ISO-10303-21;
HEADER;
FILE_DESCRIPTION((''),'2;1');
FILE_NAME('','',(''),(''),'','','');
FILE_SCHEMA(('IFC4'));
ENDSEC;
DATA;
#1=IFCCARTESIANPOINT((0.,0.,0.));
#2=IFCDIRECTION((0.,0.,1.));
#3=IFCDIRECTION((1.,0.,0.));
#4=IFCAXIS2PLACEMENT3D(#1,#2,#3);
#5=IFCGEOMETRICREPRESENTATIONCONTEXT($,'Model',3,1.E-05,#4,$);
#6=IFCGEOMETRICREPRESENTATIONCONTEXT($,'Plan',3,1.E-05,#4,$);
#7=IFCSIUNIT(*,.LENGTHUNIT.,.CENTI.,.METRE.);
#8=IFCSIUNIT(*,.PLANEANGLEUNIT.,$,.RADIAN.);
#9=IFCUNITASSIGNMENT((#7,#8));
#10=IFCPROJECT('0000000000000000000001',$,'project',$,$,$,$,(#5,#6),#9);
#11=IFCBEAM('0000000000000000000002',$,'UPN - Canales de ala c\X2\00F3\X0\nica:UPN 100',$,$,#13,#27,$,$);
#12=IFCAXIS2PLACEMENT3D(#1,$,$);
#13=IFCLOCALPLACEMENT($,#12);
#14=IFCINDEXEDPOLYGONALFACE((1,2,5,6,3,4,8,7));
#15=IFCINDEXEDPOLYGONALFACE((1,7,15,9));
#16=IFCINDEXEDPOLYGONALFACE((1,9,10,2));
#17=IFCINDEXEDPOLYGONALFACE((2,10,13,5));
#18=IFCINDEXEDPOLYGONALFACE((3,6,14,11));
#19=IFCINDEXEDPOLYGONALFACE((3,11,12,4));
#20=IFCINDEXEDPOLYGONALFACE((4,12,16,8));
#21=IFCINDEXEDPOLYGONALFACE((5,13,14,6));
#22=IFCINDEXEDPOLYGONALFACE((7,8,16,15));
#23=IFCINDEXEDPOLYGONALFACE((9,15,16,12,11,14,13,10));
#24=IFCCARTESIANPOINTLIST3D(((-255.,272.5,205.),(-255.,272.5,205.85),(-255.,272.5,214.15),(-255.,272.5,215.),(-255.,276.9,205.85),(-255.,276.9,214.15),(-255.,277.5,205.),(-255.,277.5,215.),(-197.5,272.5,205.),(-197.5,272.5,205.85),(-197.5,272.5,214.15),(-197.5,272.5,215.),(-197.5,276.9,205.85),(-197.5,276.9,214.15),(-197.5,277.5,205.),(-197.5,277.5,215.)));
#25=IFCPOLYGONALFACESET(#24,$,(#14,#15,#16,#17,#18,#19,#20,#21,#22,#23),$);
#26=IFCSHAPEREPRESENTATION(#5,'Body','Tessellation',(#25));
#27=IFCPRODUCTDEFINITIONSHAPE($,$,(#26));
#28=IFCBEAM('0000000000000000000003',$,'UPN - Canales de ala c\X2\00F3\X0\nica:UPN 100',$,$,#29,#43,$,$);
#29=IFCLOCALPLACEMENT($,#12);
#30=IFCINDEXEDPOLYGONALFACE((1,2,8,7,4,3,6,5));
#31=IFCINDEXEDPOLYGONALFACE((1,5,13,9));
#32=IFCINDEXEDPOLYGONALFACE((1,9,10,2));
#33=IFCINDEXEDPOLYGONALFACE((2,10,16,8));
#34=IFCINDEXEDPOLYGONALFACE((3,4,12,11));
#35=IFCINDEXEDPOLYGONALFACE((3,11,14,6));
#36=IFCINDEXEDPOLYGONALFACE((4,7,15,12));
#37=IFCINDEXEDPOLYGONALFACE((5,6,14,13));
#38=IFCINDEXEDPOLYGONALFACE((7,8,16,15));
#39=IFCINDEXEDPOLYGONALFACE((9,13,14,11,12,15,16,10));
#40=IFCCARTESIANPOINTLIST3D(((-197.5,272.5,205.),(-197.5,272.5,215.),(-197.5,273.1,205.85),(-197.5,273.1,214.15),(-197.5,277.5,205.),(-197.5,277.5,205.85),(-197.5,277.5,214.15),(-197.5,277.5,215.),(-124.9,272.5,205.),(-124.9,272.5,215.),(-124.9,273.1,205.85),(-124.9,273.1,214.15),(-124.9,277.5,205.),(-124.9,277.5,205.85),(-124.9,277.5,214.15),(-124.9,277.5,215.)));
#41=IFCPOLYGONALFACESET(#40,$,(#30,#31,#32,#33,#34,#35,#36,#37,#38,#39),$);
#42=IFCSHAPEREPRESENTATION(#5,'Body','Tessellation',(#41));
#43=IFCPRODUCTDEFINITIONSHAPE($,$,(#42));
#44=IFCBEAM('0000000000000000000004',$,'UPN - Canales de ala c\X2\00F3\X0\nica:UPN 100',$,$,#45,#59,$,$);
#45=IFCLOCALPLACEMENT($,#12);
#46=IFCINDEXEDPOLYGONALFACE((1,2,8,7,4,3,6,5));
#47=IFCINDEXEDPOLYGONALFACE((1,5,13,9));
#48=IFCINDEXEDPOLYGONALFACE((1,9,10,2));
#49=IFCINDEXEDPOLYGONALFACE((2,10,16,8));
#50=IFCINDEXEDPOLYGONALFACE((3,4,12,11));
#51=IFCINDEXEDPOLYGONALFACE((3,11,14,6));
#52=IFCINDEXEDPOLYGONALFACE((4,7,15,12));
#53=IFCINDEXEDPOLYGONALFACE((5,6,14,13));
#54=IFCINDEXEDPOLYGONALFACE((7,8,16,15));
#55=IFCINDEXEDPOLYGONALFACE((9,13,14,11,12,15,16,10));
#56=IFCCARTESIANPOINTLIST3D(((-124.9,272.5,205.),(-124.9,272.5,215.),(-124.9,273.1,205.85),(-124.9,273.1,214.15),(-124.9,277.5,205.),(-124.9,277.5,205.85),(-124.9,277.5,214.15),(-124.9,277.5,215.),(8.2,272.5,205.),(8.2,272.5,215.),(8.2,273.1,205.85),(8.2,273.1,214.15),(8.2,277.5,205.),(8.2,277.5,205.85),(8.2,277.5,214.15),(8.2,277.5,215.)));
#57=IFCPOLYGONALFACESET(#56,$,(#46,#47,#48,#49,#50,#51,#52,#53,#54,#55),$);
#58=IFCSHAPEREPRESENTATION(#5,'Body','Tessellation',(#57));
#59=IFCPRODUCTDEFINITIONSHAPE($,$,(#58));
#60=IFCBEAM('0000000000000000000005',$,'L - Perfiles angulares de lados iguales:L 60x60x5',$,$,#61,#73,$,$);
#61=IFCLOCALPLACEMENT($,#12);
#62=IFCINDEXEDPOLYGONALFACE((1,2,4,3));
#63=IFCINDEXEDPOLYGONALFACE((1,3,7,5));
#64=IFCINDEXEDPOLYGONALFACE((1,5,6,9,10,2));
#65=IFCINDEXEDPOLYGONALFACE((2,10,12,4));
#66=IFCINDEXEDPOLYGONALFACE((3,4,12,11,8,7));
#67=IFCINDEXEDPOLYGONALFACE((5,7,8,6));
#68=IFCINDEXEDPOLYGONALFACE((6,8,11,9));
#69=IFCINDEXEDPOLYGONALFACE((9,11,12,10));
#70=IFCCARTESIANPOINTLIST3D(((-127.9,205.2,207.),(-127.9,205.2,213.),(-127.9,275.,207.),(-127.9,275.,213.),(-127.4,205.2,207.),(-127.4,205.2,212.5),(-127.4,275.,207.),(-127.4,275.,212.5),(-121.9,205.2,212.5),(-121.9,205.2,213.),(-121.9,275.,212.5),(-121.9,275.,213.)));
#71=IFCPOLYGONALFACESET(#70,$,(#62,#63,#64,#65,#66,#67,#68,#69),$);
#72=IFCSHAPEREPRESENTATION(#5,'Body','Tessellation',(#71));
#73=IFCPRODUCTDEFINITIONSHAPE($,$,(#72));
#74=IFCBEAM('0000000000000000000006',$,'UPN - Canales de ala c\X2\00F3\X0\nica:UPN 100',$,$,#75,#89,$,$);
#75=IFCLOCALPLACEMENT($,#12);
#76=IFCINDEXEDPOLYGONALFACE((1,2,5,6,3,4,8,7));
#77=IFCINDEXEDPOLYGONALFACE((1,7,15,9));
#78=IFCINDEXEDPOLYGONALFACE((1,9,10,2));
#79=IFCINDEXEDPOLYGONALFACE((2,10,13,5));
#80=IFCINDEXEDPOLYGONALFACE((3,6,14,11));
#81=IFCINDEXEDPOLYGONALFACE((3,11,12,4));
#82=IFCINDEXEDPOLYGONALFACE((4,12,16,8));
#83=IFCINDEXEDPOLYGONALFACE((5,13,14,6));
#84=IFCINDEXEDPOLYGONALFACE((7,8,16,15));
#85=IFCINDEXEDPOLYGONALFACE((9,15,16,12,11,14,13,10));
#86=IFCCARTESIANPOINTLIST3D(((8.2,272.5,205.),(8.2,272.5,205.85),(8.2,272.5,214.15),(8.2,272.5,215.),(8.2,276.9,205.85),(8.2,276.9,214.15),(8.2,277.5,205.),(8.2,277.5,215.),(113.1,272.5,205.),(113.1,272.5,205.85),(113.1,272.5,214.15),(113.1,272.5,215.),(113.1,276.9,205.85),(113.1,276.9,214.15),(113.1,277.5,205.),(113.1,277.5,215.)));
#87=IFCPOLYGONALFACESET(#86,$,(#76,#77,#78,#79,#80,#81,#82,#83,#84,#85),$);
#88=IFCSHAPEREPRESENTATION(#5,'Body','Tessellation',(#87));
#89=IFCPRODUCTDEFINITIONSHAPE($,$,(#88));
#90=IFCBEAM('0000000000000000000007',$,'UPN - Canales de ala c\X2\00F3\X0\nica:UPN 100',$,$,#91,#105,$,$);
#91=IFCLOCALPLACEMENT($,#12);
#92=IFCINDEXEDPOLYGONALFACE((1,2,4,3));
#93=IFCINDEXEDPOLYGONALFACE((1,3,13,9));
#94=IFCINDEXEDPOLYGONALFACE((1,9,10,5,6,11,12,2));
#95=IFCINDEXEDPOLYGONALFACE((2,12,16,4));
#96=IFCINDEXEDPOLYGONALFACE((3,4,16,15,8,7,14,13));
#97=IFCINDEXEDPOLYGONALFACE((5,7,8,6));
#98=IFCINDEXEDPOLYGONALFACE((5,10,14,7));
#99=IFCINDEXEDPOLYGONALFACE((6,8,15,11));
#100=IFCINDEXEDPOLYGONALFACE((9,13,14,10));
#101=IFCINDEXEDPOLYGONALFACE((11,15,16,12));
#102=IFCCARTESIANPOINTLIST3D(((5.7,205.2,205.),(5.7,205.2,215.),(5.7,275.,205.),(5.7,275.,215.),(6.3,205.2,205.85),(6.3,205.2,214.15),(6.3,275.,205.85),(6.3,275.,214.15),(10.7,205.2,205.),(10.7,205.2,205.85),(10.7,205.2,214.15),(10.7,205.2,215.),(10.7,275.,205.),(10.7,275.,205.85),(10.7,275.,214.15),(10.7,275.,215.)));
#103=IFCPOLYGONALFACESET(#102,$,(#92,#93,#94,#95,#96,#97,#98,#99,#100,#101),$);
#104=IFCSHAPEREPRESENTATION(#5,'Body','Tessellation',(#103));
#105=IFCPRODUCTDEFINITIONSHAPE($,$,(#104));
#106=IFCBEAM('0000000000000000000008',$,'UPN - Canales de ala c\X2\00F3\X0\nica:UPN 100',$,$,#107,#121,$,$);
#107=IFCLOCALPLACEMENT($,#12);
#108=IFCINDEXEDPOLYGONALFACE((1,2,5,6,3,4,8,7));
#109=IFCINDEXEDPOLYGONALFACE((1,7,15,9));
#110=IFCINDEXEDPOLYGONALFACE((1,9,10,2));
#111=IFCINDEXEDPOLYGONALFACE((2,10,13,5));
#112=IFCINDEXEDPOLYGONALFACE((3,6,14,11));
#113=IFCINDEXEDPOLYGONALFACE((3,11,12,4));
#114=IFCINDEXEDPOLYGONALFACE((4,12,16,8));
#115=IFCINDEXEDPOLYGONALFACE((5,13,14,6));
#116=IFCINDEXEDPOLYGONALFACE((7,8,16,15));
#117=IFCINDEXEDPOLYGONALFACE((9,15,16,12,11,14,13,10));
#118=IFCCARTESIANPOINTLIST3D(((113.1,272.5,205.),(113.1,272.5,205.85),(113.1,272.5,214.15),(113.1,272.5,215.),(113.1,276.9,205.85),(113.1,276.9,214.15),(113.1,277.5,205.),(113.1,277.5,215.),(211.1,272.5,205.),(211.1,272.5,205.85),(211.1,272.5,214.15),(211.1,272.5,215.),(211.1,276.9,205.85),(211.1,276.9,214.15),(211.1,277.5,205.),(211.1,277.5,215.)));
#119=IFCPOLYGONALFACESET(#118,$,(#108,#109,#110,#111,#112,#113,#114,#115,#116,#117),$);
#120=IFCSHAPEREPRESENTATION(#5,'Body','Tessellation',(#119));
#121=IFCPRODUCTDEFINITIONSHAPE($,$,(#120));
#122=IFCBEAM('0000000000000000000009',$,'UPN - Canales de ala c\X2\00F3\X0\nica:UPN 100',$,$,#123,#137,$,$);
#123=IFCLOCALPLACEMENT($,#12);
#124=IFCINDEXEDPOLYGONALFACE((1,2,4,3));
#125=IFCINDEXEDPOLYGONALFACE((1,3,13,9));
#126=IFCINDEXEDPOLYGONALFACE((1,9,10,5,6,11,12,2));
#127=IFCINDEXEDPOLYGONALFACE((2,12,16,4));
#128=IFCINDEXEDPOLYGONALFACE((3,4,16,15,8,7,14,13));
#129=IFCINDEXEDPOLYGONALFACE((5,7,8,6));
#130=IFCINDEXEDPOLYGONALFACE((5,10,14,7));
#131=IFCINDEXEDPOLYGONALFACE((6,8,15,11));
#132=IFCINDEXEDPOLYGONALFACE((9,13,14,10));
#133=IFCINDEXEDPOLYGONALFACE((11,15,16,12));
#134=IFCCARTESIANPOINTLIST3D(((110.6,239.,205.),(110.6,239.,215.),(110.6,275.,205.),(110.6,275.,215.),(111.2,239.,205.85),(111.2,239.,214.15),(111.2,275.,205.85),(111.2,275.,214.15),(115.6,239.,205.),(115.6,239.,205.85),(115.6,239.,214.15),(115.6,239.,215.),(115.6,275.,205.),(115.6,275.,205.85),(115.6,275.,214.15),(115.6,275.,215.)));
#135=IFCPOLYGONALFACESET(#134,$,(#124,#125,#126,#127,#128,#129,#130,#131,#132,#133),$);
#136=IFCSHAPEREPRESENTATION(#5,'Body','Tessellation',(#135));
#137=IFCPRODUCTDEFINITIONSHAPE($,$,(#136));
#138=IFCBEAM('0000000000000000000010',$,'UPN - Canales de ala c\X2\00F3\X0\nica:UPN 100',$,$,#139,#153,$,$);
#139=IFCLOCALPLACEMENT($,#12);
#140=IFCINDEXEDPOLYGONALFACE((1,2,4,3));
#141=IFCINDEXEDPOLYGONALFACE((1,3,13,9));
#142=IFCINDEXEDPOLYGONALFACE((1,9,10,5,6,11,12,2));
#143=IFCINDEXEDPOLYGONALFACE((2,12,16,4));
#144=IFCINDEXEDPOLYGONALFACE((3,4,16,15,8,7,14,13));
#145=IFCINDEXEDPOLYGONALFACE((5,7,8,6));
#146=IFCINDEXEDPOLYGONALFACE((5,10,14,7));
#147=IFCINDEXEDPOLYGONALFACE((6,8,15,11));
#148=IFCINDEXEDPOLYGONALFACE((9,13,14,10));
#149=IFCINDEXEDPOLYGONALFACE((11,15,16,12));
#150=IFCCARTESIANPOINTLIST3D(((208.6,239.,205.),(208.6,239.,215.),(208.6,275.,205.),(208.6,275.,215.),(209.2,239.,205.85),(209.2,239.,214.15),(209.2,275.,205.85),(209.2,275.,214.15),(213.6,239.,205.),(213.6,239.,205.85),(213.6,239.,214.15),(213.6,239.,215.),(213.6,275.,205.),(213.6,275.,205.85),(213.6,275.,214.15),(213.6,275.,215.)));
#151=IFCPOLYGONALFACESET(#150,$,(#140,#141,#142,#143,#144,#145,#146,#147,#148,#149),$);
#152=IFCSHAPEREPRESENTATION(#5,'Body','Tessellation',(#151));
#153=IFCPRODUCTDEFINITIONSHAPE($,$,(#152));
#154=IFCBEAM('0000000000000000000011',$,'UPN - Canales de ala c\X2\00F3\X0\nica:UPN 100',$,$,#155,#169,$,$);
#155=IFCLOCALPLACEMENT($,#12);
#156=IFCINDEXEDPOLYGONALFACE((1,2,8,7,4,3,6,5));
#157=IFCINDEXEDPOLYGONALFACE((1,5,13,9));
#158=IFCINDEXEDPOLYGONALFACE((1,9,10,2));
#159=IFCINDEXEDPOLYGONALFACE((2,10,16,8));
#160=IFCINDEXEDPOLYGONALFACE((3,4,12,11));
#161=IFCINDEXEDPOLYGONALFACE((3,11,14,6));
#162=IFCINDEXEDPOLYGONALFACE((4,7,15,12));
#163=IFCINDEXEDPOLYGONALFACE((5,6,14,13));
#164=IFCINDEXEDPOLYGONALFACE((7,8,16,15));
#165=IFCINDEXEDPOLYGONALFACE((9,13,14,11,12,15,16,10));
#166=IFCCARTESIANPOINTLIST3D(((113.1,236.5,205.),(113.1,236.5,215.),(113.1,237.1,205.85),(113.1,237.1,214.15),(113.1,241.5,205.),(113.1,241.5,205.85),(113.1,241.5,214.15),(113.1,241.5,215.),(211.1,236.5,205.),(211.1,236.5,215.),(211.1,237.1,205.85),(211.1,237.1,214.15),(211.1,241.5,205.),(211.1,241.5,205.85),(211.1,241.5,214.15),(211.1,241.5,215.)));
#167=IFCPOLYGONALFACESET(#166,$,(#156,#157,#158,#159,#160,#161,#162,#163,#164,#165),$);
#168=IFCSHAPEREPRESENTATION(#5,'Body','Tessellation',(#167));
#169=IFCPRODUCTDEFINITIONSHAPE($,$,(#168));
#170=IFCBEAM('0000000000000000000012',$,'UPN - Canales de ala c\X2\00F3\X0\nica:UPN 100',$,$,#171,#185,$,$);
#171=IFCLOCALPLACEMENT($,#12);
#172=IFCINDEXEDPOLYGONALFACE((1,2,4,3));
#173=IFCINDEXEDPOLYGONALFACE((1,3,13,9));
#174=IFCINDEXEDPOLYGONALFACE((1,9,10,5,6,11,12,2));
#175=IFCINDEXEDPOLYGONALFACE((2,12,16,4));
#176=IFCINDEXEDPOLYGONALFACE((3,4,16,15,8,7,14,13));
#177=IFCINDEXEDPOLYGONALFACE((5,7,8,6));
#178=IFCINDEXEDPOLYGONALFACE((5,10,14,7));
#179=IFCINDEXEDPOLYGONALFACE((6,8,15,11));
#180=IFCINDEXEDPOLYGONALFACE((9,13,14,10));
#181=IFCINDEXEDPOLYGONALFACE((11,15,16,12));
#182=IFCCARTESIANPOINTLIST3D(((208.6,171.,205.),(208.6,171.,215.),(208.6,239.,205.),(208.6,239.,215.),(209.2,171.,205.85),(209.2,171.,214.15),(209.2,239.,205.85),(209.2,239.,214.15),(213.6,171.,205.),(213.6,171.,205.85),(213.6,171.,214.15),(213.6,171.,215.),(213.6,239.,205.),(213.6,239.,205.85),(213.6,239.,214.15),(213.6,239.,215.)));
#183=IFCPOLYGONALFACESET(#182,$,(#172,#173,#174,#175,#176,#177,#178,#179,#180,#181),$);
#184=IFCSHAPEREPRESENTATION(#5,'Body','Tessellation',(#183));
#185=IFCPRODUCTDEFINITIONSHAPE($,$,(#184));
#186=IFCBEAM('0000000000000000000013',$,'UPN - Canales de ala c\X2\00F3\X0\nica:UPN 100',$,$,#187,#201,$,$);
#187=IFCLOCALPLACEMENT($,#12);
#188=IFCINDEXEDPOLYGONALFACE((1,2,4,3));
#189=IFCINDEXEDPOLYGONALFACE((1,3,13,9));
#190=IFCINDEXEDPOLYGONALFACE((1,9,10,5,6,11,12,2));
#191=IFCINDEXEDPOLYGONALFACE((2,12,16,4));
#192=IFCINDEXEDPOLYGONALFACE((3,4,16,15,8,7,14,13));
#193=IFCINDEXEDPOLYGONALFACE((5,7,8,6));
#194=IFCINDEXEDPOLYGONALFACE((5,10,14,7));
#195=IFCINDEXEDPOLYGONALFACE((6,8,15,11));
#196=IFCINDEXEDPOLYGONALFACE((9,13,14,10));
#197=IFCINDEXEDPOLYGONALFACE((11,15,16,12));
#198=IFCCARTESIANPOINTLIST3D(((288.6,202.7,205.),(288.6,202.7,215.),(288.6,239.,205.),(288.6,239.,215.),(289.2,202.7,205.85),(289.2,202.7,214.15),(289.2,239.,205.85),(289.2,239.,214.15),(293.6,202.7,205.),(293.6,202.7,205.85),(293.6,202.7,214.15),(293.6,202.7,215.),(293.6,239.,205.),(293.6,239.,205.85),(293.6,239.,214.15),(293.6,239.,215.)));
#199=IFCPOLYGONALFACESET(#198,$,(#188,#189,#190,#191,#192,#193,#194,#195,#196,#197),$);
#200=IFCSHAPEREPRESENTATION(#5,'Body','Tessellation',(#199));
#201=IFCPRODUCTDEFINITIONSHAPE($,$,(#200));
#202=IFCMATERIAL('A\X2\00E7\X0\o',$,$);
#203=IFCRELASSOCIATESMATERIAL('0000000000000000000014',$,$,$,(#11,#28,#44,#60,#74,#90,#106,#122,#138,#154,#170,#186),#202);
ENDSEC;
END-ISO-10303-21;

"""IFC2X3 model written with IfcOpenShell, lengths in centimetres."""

from ifc_helpers import new_model, si_unit, frame, frame_2d, origin_with_axes, origin_2d_with_axis, place, context, project, polyline, u_section, outline, extrude, material, element, save


model = new_model("IFC2X3")

# Units and contexts
model_context = context("Model", 3, precision=1e-05, world=origin_with_axes())
plan_context = context("Plan", 3, precision=1e-05, world=origin_with_axes())
ifc_project = project(units=[si_unit("LENGTHUNIT", "METRE", prefix="CENTI"), si_unit("PLANEANGLEUNIT", "RADIAN")], contexts=[model_context, plan_context])

# Shared definitions
ifc_material = material(Name="Aço")

# Beams
beam_1_placement = place(None, frame((-197.5, 275.0, 210.0), z_axis=(-1.0, 0.0, 0.0), x_axis=(0.0, -1.0, 0.0)))
element("IfcBeam", 1, at=beam_1_placement, material=ifc_material, Name="UPN - Canales de ala cónica:UPN 100", context=model_context, shape_type="SweptSolid", body=[
    extrude(u_section(Depth=10.0, FlangeWidth=5.0, WebThickness=0.6, FlangeThickness=0.85, FilletRadius=0.0, EdgeRadius=0.0, FlangeSlope=0.0, CentreOfGravityInX=0.0, at=origin_2d_with_axis()), origin_with_axes(), (0.0, 0.0, 1.0), 57.5),
])
beam_2_placement = place(None, frame((-124.9, 275.0, 210.0), z_axis=(-1.0, 0.0, 0.0), x_axis=(0.0, 1.0, 0.0)))
element("IfcBeam", 2, at=beam_2_placement, material=ifc_material, Name="UPN - Canales de ala cónica:UPN 100", context=model_context, shape_type="SweptSolid", body=[
    extrude(u_section(Depth=10.0, FlangeWidth=5.0, WebThickness=0.6, FlangeThickness=0.85, FilletRadius=0.0, EdgeRadius=0.0, FlangeSlope=0.0, CentreOfGravityInX=0.0, at=origin_2d_with_axis()), origin_with_axes(), (0.0, 0.0, 1.0), 72.6),
])
beam_3_placement = place(None, frame((8.2, 275.0, 210.0), z_axis=(-1.0, 0.0, 0.0), x_axis=(0.0, 1.0, 0.0)))
element("IfcBeam", 3, at=beam_3_placement, material=ifc_material, Name="UPN - Canales de ala cónica:UPN 100", context=model_context, shape_type="SweptSolid", body=[
    extrude(u_section(Depth=10.0, FlangeWidth=5.0, WebThickness=0.6, FlangeThickness=0.85, FilletRadius=0.0, EdgeRadius=0.0, FlangeSlope=0.0, CentreOfGravityInX=0.0, at=origin_2d_with_axis()), origin_with_axes(), (0.0, 0.0, 1.0), 133.1),
])
beam_4_placement = place(None, frame((-124.9, 205.2, 210.0), z_axis=(0.0, 1.0, 0.0), x_axis=(-1.0, 0.0, 0.0)))
element("IfcBeam", 4, at=beam_4_placement, material=ifc_material, Name="L - Perfiles angulares de lados iguales:L 60x60x5", context=model_context, shape_type="SweptSolid", body=[
    extrude(outline(polyline([(3.0, -3.0), (3.0, 3.0), (-3.0, 3.0), (-3.0, 2.5), (2.5, 2.5), (2.5, -3.0), (3.0, -3.0)])), origin_with_axes(), (0.0, 0.0, 1.0), 69.8),
])
beam_5_placement = place(None, frame((113.1, 275.0, 210.0), z_axis=(-1.0, 0.0, 0.0), x_axis=(0.0, -1.0, 0.0)))
element("IfcBeam", 5, at=beam_5_placement, material=ifc_material, Name="UPN - Canales de ala cónica:UPN 100", context=model_context, shape_type="SweptSolid", body=[
    extrude(u_section(Depth=10.0, FlangeWidth=5.0, WebThickness=0.6, FlangeThickness=0.85, FilletRadius=0.0, EdgeRadius=0.0, FlangeSlope=0.0, CentreOfGravityInX=0.0, at=origin_2d_with_axis()), origin_with_axes(), (0.0, 0.0, 1.0), 104.9),
])
beam_6_placement = place(None, frame((8.2, 205.2, 210.0), z_axis=(0.0, 1.0, 0.0), x_axis=(1.0, 0.0, 0.0)))
element("IfcBeam", 6, at=beam_6_placement, material=ifc_material, Name="UPN - Canales de ala cónica:UPN 100", context=model_context, shape_type="SweptSolid", body=[
    extrude(u_section(Depth=10.0, FlangeWidth=5.0, WebThickness=0.6, FlangeThickness=0.85, FilletRadius=0.0, EdgeRadius=0.0, FlangeSlope=0.0, CentreOfGravityInX=0.0, at=frame_2d((0.0, 0.0), x_axis=(1.0, 0.0))), origin_with_axes(), (0.0, 0.0, 1.0), 69.8),
])
beam_7_placement = place(None, frame((211.1, 275.0, 210.0), z_axis=(-1.0, 0.0, 0.0), x_axis=(0.0, -1.0, 0.0)))
element("IfcBeam", 7, at=beam_7_placement, material=ifc_material, Name="UPN - Canales de ala cónica:UPN 100", context=model_context, shape_type="SweptSolid", body=[
    extrude(u_section(Depth=10.0, FlangeWidth=5.0, WebThickness=0.6, FlangeThickness=0.85, FilletRadius=0.0, EdgeRadius=0.0, FlangeSlope=0.0, CentreOfGravityInX=0.0, at=origin_2d_with_axis()), origin_with_axes(), (0.0, 0.0, 1.0), 98.0),
])
for number, where, z_axis, x_axis, name in (
    (8, (113.1, 239.0, 210.0), (0.0, 1.0, 0.0), (1.0, 0.0, 0.0), "UPN - Canales de ala cónica:UPN 100"),
    (9, (211.1, 239.0, 210.0), (0.0, 1.0, 0.0), (1.0, 0.0, 0.0), "UPN - Canales de ala cónica:UPN 100"),
):
    element("IfcBeam", number, at=place(None, frame(where, z_axis=z_axis, x_axis=x_axis)), material=ifc_material, Name=name, context=model_context, shape_type="SweptSolid", body=[
        extrude(u_section(Depth=10.0, FlangeWidth=5.0, WebThickness=0.6, FlangeThickness=0.85, FilletRadius=0.0, EdgeRadius=0.0, FlangeSlope=0.0, CentreOfGravityInX=0.0, at=origin_2d_with_axis()), origin_with_axes(), (0.0, 0.0, 1.0), 36.0),
    ])
beam_8_placement = place(None, frame((211.1, 239.0, 210.0), z_axis=(-1.0, 0.0, 0.0), x_axis=(0.0, 1.0, 0.0)))
element("IfcBeam", 10, at=beam_8_placement, material=ifc_material, Name="UPN - Canales de ala cónica:UPN 100", context=model_context, shape_type="SweptSolid", body=[
    extrude(u_section(Depth=10.0, FlangeWidth=5.0, WebThickness=0.6, FlangeThickness=0.85, FilletRadius=0.0, EdgeRadius=0.0, FlangeSlope=0.0, CentreOfGravityInX=0.0, at=origin_2d_with_axis()), origin_with_axes(), (0.0, 0.0, 1.0), 98.0),
])
beam_9_placement = place(None, frame((211.1, 171.0, 210.0), z_axis=(0.0, 1.0, 0.0), x_axis=(1.0, 0.0, 0.0)))
element("IfcBeam", 11, at=beam_9_placement, material=ifc_material, Name="UPN - Canales de ala cónica:UPN 100", context=model_context, shape_type="SweptSolid", body=[
    extrude(u_section(Depth=10.0, FlangeWidth=5.0, WebThickness=0.6, FlangeThickness=0.85, FilletRadius=0.0, EdgeRadius=0.0, FlangeSlope=0.0, CentreOfGravityInX=0.0, at=origin_2d_with_axis()), origin_with_axes(), (0.0, 0.0, 1.0), 68.0),
])
beam_10_placement = place(None, frame((291.1, 202.7, 210.0), z_axis=(0.0, 1.0, 0.0), x_axis=(1.0, 0.0, 0.0)))
element("IfcBeam", 12, at=beam_10_placement, material=ifc_material, Name="UPN - Canales de ala cónica:UPN 100", context=model_context, shape_type="SweptSolid", body=[
    extrude(u_section(Depth=10.0, FlangeWidth=5.0, WebThickness=0.6, FlangeThickness=0.85, FilletRadius=0.0, EdgeRadius=0.0, FlangeSlope=0.0, CentreOfGravityInX=0.0, at=origin_2d_with_axis()), origin_with_axes(), (0.0, 0.0, 1.0), 36.3),
])

save(model, "model.ifc")
